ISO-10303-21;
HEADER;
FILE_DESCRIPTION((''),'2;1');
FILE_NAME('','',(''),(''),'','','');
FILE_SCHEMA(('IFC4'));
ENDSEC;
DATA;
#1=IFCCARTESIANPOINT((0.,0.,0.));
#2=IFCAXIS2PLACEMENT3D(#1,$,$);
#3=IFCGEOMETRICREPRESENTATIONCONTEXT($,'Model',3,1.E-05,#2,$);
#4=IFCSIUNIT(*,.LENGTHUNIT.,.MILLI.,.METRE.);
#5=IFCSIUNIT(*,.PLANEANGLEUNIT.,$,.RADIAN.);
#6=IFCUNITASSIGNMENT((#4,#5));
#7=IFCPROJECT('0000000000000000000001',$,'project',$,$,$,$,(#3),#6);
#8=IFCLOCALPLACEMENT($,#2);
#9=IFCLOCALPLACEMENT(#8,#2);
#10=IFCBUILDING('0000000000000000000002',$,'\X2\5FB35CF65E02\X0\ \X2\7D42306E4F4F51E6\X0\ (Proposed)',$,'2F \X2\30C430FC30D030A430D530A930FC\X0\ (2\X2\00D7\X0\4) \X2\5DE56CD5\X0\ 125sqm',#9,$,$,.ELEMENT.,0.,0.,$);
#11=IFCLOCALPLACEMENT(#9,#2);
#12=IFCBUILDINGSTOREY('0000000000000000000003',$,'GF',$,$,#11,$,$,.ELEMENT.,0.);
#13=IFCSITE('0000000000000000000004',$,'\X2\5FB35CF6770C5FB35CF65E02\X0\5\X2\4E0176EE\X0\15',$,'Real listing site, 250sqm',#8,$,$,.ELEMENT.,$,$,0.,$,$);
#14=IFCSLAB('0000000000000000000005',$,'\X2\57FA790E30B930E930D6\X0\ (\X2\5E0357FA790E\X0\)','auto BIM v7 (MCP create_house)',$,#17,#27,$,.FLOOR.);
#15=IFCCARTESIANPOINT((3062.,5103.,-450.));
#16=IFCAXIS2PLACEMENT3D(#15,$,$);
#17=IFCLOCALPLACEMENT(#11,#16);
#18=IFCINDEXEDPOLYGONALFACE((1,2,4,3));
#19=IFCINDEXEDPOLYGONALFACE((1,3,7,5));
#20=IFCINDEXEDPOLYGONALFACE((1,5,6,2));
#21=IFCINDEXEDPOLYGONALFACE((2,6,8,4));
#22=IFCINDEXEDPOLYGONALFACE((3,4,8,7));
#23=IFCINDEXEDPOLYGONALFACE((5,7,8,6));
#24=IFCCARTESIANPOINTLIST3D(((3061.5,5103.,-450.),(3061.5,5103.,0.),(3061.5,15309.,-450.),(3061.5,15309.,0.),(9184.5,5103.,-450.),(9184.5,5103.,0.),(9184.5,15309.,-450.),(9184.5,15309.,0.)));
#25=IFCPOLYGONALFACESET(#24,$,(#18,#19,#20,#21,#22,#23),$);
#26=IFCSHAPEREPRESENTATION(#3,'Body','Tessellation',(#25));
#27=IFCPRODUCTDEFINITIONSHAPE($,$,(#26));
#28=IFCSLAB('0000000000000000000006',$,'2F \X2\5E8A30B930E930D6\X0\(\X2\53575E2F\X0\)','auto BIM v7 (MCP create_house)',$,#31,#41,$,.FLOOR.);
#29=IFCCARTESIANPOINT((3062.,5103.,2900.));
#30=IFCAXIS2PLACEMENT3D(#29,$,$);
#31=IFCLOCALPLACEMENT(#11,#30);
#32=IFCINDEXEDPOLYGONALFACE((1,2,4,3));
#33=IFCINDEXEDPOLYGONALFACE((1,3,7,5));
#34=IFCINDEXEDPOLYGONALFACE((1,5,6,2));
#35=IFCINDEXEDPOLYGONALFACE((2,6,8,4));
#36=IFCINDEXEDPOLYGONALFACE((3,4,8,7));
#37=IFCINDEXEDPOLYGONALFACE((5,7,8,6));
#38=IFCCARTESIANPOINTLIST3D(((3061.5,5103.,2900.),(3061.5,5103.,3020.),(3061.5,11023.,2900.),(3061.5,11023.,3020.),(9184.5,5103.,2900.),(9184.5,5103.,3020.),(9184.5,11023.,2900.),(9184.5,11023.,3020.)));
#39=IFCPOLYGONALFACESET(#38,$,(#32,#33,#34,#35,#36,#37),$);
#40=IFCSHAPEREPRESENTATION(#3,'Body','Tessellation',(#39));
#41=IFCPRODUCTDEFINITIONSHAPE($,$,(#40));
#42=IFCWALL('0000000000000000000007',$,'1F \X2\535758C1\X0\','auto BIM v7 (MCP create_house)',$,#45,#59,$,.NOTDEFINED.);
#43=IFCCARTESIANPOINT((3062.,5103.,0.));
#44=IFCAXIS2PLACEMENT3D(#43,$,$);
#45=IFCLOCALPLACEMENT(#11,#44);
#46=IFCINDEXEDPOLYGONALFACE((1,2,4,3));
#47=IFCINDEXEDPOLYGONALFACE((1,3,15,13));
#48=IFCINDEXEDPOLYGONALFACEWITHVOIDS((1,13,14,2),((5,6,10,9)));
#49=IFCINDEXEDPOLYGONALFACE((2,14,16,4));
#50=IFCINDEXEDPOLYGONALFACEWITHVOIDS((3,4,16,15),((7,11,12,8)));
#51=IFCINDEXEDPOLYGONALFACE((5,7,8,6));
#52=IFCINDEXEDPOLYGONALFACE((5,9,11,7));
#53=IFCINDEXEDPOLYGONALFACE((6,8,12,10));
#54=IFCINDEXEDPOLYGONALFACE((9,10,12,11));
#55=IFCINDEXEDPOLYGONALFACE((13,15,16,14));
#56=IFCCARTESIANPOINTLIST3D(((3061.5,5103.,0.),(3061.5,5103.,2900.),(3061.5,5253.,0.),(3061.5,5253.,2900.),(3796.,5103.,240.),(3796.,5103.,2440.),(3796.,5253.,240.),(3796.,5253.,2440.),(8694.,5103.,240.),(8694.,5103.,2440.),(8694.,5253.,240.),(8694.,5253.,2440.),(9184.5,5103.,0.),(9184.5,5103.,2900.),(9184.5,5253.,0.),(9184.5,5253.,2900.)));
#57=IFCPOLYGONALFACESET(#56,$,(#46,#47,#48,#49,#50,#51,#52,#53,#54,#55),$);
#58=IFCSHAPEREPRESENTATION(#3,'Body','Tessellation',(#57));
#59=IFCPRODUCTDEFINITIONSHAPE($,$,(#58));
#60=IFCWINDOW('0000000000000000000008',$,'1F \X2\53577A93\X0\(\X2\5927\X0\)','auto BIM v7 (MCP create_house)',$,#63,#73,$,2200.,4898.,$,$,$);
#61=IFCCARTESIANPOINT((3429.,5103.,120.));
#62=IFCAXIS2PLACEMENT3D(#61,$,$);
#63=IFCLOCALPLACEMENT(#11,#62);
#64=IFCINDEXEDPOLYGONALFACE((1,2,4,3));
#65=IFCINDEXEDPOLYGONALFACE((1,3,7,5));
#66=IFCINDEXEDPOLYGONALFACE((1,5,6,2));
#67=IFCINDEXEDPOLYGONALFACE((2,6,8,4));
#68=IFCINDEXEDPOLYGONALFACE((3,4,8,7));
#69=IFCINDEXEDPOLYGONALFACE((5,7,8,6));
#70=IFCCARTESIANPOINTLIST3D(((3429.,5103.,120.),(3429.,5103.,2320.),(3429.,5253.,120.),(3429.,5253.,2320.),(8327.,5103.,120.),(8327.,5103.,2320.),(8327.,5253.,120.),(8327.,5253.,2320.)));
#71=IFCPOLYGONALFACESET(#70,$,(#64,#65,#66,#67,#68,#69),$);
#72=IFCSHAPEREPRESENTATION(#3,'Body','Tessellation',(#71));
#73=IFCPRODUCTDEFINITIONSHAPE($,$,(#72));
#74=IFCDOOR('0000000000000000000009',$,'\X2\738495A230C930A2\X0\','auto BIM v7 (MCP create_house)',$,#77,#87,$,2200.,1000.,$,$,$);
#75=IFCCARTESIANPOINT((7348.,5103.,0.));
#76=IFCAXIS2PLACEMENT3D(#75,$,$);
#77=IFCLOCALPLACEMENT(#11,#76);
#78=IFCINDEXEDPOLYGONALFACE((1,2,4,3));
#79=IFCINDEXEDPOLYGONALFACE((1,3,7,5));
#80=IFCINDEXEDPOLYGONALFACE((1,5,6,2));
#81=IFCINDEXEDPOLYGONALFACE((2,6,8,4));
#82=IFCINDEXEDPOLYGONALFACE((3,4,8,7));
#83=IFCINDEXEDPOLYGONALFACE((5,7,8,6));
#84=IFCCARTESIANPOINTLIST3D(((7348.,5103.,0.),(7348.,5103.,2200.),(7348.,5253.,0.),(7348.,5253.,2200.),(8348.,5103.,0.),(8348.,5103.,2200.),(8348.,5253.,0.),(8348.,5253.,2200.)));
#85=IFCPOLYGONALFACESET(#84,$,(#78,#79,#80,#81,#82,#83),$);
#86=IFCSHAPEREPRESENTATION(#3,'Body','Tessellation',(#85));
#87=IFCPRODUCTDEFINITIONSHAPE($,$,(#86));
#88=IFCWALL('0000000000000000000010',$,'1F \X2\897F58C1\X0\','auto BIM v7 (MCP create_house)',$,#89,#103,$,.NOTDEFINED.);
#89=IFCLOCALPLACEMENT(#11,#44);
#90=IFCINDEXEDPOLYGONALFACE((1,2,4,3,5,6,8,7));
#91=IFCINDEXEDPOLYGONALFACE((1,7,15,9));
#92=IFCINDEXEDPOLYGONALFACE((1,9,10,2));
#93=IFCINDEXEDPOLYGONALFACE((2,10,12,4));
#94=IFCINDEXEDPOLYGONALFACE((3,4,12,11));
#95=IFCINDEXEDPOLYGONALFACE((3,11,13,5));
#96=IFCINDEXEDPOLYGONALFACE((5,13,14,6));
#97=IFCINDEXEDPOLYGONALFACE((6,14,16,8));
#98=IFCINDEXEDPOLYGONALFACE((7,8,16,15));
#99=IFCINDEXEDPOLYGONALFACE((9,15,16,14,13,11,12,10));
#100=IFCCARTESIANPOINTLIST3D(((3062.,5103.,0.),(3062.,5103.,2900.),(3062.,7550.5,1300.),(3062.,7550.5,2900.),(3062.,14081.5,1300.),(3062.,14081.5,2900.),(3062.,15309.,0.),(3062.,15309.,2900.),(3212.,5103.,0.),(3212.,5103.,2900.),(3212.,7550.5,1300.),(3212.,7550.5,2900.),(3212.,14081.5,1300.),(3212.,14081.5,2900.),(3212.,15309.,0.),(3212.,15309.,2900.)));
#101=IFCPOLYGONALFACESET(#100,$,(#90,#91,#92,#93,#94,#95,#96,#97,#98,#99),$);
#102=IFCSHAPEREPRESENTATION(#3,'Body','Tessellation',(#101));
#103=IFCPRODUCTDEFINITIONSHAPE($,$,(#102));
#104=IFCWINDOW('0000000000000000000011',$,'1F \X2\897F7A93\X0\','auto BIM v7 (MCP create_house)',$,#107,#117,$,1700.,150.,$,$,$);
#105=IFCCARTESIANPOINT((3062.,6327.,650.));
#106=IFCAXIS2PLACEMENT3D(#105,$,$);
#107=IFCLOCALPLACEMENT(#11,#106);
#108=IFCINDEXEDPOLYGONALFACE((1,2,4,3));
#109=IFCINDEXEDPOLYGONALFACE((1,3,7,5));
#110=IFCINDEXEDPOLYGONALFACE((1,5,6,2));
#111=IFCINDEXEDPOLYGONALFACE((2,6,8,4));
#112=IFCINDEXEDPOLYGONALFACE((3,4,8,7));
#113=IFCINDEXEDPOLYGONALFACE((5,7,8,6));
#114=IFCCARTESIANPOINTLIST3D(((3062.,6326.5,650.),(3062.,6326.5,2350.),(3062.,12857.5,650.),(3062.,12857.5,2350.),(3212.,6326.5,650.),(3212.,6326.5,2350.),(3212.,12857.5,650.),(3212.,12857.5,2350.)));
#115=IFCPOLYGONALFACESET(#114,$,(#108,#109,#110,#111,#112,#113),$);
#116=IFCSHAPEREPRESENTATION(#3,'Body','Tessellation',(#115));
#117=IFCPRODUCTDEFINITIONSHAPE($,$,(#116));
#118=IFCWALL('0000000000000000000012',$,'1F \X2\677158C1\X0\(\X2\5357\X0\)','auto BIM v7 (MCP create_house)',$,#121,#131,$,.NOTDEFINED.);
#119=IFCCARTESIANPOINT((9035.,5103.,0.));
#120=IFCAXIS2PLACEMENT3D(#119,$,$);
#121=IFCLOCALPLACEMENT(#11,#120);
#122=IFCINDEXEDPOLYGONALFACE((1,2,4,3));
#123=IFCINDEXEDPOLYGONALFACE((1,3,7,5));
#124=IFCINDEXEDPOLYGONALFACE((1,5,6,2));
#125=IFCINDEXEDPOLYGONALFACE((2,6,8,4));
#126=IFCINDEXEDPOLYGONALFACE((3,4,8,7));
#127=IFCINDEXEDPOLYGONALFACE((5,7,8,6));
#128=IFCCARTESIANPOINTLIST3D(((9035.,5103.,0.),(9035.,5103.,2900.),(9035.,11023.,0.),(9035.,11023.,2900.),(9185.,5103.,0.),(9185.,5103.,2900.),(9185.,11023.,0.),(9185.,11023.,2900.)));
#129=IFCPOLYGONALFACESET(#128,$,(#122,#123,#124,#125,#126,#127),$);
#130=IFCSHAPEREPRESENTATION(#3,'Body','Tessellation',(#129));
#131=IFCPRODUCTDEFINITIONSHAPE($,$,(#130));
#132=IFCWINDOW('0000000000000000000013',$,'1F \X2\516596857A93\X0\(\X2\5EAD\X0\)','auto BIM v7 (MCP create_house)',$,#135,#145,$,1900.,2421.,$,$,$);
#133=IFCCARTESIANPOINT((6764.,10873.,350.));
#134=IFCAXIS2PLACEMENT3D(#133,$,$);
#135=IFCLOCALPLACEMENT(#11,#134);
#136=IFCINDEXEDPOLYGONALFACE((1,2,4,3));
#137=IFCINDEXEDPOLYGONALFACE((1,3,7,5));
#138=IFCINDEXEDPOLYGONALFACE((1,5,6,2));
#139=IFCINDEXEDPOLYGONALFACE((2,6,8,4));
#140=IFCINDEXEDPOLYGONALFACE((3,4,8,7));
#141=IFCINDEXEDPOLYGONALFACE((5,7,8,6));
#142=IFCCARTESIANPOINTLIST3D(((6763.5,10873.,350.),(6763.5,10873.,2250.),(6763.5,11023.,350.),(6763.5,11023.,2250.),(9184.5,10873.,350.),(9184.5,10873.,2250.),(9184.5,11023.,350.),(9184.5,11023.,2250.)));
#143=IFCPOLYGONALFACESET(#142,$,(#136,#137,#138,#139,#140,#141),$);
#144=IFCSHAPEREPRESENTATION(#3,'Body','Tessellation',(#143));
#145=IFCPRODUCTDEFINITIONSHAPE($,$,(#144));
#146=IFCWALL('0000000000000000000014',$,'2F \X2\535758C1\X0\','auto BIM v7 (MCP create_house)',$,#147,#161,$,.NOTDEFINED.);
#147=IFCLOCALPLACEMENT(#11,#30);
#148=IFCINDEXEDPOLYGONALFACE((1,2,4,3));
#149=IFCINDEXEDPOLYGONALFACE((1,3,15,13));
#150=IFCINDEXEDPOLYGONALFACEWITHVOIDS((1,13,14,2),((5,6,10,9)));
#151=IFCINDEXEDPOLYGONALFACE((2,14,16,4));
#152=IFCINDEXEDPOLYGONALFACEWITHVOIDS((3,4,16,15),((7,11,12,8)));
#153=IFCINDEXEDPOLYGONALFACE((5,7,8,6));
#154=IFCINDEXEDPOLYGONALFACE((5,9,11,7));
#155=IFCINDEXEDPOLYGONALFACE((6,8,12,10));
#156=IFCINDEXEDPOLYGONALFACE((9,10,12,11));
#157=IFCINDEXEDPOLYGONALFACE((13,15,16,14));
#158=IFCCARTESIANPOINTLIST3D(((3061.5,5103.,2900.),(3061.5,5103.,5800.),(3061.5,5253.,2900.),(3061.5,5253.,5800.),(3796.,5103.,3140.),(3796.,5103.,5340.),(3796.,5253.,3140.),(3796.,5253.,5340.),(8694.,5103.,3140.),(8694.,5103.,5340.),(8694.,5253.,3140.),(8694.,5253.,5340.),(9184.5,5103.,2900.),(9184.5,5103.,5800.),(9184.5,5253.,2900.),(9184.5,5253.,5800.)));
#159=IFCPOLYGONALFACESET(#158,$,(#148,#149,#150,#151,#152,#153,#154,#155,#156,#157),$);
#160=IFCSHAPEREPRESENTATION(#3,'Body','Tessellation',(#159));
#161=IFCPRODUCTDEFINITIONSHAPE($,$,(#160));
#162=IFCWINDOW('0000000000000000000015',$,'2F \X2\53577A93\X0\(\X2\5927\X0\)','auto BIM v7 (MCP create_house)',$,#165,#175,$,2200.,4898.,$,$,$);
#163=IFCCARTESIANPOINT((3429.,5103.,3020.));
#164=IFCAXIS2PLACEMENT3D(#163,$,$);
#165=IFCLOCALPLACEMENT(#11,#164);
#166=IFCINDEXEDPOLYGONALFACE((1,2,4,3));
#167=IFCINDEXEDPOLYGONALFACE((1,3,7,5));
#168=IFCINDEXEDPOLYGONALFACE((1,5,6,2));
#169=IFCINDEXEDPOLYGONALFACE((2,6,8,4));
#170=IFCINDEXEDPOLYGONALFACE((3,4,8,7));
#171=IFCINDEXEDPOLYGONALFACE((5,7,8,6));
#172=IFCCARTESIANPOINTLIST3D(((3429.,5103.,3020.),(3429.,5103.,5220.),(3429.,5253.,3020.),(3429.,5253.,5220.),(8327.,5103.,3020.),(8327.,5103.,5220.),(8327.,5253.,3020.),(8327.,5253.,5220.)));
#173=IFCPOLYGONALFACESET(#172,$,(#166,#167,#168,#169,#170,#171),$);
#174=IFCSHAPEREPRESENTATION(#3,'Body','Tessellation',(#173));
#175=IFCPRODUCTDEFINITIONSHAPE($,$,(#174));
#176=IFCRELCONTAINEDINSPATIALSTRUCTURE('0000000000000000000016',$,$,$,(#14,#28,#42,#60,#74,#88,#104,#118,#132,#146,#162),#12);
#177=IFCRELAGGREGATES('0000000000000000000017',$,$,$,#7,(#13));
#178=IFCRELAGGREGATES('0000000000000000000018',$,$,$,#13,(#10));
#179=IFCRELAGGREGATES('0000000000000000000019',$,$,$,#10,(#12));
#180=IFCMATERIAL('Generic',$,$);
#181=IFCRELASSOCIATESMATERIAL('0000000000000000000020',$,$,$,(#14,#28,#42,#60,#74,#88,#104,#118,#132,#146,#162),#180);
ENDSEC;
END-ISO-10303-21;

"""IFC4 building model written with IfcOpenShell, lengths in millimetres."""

from ifc_helpers import new_model, si_unit, frame, frame_2d, origin, place, context, project, spatial, rectangle, extrude, material, element, fill, save


model = new_model("IFC4")

# Units and contexts
model_context = context("Model", 3, precision=1e-05, world=origin())
ifc_project = project(units=[si_unit("LENGTHUNIT", "METRE", prefix="MILLI"), si_unit("PLANEANGLEUNIT", "RADIAN")], contexts=[model_context])

# Site, building, storey
site_placement = place(None, origin())
site = spatial("IfcSite", under=ifc_project, at=site_placement, Name="徳島県徳島市5丁目15", ObjectType="Real listing site, 250sqm", CompositionType="ELEMENT", RefElevation=0.0)
building_placement = place(site_placement, origin())
building = spatial("IfcBuilding", under=site, at=building_placement, Name="徳島市 終の住処 (Proposed)", ObjectType="2F ツーバイフォー (2×4) 工法 125sqm", CompositionType="ELEMENT", ElevationOfRefHeight=0.0, ElevationOfTerrain=0.0)
storey_placement = place(building_placement, origin())
storey = spatial("IfcBuildingStorey", under=building, at=storey_placement, Name="GF", CompositionType="ELEMENT", Elevation=0.0)

# Slabs
ifc_material = material(Name="Generic")
slab_1_placement = place(storey_placement, frame((3062.0, 5103.0, -450.0)))
element("IfcSlab", 1, at=slab_1_placement, inside=storey, material=ifc_material, Name="基礎スラブ (布基礎)", Description="auto BIM v7 (MCP create_house)", PredefinedType="FLOOR", context=model_context, shape_type="SweptSolid", body=[
    extrude(rectangle(XDim=6123.0, YDim=10206.0, at=frame_2d((3061.0, 5103.0))), frame((3062.0, 5103.0, -450.0)), (0.0, 0.0, 1.0), 450.0),
])
slab_2_placement = place(storey_placement, frame((3062.0, 5103.0, 2900.0)))
element("IfcSlab", 2, at=slab_2_placement, inside=storey, material=ifc_material, Name="2F 床スラブ(南帯)", Description="auto BIM v7 (MCP create_house)", PredefinedType="FLOOR", context=model_context, shape_type="SweptSolid", body=[
    extrude(rectangle(XDim=6123.0, YDim=5920.0, at=frame_2d((3061.0, 2960.0))), frame((3062.0, 5103.0, 2900.0)), (0.0, 0.0, 1.0), 120.0),
])

# Wall, openings, window, door
wall_1_placement = place(storey_placement, frame((3062.0, 5103.0, 0.0)))
wall_1 = element("IfcWall", 3, at=wall_1_placement, inside=storey, material=ifc_material, Name="1F 南壁", Description="auto BIM v7 (MCP create_house)", PredefinedType="NOTDEFINED", context=model_context, shape_type="SweptSolid", body=[
    extrude(rectangle(XDim=6123.0, YDim=150.0, at=frame_2d((3061.0, 75.0))), frame((3062.0, 5103.0, 0.0)), (0.0, 0.0, 1.0), 2900.0),
])
opening_1_placement = place(storey_placement, frame((3429.0, 5103.0, 120.0)))
opening_1 = element("IfcOpeningElement", 4, at=opening_1_placement, cuts=wall_1, PredefinedType="NOTDEFINED", context=model_context, shape_type="SweptSolid", body=[
    extrude(rectangle(XDim=4898.0, YDim=150.0, at=frame_2d((2449.0, 75.0))), frame((3429.0, 5103.0, 120.0)), (0.0, 0.0, 1.0), 2200.0),
])
opening_2_placement = place(storey_placement, frame((7348.0, 5103.0, 0.0)))
opening_2 = element("IfcOpeningElement", 5, at=opening_2_placement, cuts=wall_1, PredefinedType="NOTDEFINED", context=model_context, shape_type="SweptSolid", body=[
    extrude(rectangle(XDim=1000.0, YDim=150.0, at=frame_2d((500.0, 75.0))), frame((7348.0, 5103.0, 0.0)), (0.0, 0.0, 1.0), 2200.0),
])
window_1_placement = place(storey_placement, frame((3429.0, 5103.0, 120.0)))
window_1 = element("IfcWindow", 6, at=window_1_placement, inside=storey, material=ifc_material, Name="1F 南窓(大)", Description="auto BIM v7 (MCP create_house)", OverallHeight=2200.0, OverallWidth=4898.0, context=model_context, shape_type="SweptSolid", body=[
    extrude(rectangle(XDim=4898.0, YDim=150.0, at=frame_2d((2449.0, 75.0))), frame((3429.0, 5103.0, 120.0)), (0.0, 0.0, 1.0), 2200.0),
])
fill(opening_1, window_1)
door_placement = place(storey_placement, frame((7348.0, 5103.0, 0.0)))
door = element("IfcDoor", 7, at=door_placement, inside=storey, material=ifc_material, Name="玄関ドア", Description="auto BIM v7 (MCP create_house)", OverallHeight=2200.0, OverallWidth=1000.0, context=model_context, shape_type="SweptSolid", body=[
    extrude(rectangle(XDim=1000.0, YDim=150.0, at=frame_2d((500.0, 75.0))), frame((7348.0, 5103.0, 0.0)), (0.0, 0.0, 1.0), 2200.0),
])
fill(opening_2, door)

# Walls, openings, windows
wall_2_placement = place(storey_placement, frame((3062.0, 5103.0, 0.0)))
wall_2 = element("IfcWall", 8, at=wall_2_placement, inside=storey, material=ifc_material, Name="1F 西壁", Description="auto BIM v7 (MCP create_house)", PredefinedType="NOTDEFINED", context=model_context, shape_type="SweptSolid", body=[
    extrude(rectangle(XDim=150.0, YDim=10206.0, at=frame_2d((75.0, 5103.0))), frame((3062.0, 5103.0, 0.0)), (0.0, 0.0, 1.0), 2900.0),
])
opening_3_placement = place(storey_placement, frame((3062.0, 6327.0, 650.0)))
opening_3 = element("IfcOpeningElement", 9, at=opening_3_placement, cuts=wall_2, PredefinedType="NOTDEFINED", context=model_context, shape_type="SweptSolid", body=[
    extrude(rectangle(XDim=150.0, YDim=6531.0, at=frame_2d((75.0, 3265.0))), frame((3062.0, 6327.0, 650.0)), (0.0, 0.0, 1.0), 1700.0),
])
window_2_placement = place(storey_placement, frame((3062.0, 6327.0, 650.0)))
window_2 = element("IfcWindow", 10, at=window_2_placement, inside=storey, material=ifc_material, Name="1F 西窓", Description="auto BIM v7 (MCP create_house)", OverallHeight=1700.0, OverallWidth=150.0, context=model_context, shape_type="SweptSolid", body=[
    extrude(rectangle(XDim=150.0, YDim=6531.0, at=frame_2d((75.0, 3265.0))), frame((3062.0, 6327.0, 650.0)), (0.0, 0.0, 1.0), 1700.0),
])
fill(opening_3, window_2)
wall_3_placement = place(storey_placement, frame((9035.0, 5103.0, 0.0)))
wall_3 = element("IfcWall", 11, at=wall_3_placement, inside=storey, material=ifc_material, Name="1F 東壁(南)", Description="auto BIM v7 (MCP create_house)", PredefinedType="NOTDEFINED", context=model_context, shape_type="SweptSolid", body=[
    extrude(rectangle(XDim=150.0, YDim=5920.0, at=frame_2d((75.0, 2960.0))), frame((9035.0, 5103.0, 0.0)), (0.0, 0.0, 1.0), 2900.0),
])
opening_4_placement = place(storey_placement, frame((6764.0, 10873.0, 350.0)))
opening_4 = element("IfcOpeningElement", 12, at=opening_4_placement, cuts=wall_3, PredefinedType="NOTDEFINED", context=model_context, shape_type="SweptSolid", body=[
    extrude(rectangle(XDim=2421.0, YDim=150.0, at=frame_2d((1210.0, 75.0))), frame((6764.0, 10873.0, 350.0)), (0.0, 0.0, 1.0), 1900.0),
])
window_3_placement = place(storey_placement, frame((6764.0, 10873.0, 350.0)))
window_3 = element("IfcWindow", 13, at=window_3_placement, inside=storey, material=ifc_material, Name="1F 入隅窓(庭)", Description="auto BIM v7 (MCP create_house)", OverallHeight=1900.0, OverallWidth=2421.0, context=model_context, shape_type="SweptSolid", body=[
    extrude(rectangle(XDim=2421.0, YDim=150.0, at=frame_2d((1210.0, 75.0))), frame((6764.0, 10873.0, 350.0)), (0.0, 0.0, 1.0), 1900.0),
])
fill(opening_4, window_3)

# Wall, opening, window
wall_4_placement = place(storey_placement, frame((3062.0, 5103.0, 2900.0)))
wall_4 = element("IfcWall", 14, at=wall_4_placement, inside=storey, material=ifc_material, Name="2F 南壁", Description="auto BIM v7 (MCP create_house)", PredefinedType="NOTDEFINED", context=model_context, shape_type="SweptSolid", body=[
    extrude(rectangle(XDim=6123.0, YDim=150.0, at=frame_2d((3061.0, 75.0))), frame((3062.0, 5103.0, 2900.0)), (0.0, 0.0, 1.0), 2900.0),
])
opening_5_placement = place(storey_placement, frame((3429.0, 5103.0, 3020.0)))
opening_5 = element("IfcOpeningElement", 15, at=opening_5_placement, cuts=wall_4, PredefinedType="NOTDEFINED", context=model_context, shape_type="SweptSolid", body=[
    extrude(rectangle(XDim=4898.0, YDim=150.0, at=frame_2d((2449.0, 75.0))), frame((3429.0, 5103.0, 3020.0)), (0.0, 0.0, 1.0), 2200.0),
])
window_4_placement = place(storey_placement, frame((3429.0, 5103.0, 3020.0)))
window_4 = element("IfcWindow", 16, at=window_4_placement, inside=storey, material=ifc_material, Name="2F 南窓(大)", Description="auto BIM v7 (MCP create_house)", OverallHeight=2200.0, OverallWidth=4898.0, context=model_context, shape_type="SweptSolid", body=[
    extrude(rectangle(XDim=4898.0, YDim=150.0, at=frame_2d((2449.0, 75.0))), frame((3429.0, 5103.0, 3020.0)), (0.0, 0.0, 1.0), 2200.0),
])
fill(opening_5, window_4)

save(model, "model.ifc")
